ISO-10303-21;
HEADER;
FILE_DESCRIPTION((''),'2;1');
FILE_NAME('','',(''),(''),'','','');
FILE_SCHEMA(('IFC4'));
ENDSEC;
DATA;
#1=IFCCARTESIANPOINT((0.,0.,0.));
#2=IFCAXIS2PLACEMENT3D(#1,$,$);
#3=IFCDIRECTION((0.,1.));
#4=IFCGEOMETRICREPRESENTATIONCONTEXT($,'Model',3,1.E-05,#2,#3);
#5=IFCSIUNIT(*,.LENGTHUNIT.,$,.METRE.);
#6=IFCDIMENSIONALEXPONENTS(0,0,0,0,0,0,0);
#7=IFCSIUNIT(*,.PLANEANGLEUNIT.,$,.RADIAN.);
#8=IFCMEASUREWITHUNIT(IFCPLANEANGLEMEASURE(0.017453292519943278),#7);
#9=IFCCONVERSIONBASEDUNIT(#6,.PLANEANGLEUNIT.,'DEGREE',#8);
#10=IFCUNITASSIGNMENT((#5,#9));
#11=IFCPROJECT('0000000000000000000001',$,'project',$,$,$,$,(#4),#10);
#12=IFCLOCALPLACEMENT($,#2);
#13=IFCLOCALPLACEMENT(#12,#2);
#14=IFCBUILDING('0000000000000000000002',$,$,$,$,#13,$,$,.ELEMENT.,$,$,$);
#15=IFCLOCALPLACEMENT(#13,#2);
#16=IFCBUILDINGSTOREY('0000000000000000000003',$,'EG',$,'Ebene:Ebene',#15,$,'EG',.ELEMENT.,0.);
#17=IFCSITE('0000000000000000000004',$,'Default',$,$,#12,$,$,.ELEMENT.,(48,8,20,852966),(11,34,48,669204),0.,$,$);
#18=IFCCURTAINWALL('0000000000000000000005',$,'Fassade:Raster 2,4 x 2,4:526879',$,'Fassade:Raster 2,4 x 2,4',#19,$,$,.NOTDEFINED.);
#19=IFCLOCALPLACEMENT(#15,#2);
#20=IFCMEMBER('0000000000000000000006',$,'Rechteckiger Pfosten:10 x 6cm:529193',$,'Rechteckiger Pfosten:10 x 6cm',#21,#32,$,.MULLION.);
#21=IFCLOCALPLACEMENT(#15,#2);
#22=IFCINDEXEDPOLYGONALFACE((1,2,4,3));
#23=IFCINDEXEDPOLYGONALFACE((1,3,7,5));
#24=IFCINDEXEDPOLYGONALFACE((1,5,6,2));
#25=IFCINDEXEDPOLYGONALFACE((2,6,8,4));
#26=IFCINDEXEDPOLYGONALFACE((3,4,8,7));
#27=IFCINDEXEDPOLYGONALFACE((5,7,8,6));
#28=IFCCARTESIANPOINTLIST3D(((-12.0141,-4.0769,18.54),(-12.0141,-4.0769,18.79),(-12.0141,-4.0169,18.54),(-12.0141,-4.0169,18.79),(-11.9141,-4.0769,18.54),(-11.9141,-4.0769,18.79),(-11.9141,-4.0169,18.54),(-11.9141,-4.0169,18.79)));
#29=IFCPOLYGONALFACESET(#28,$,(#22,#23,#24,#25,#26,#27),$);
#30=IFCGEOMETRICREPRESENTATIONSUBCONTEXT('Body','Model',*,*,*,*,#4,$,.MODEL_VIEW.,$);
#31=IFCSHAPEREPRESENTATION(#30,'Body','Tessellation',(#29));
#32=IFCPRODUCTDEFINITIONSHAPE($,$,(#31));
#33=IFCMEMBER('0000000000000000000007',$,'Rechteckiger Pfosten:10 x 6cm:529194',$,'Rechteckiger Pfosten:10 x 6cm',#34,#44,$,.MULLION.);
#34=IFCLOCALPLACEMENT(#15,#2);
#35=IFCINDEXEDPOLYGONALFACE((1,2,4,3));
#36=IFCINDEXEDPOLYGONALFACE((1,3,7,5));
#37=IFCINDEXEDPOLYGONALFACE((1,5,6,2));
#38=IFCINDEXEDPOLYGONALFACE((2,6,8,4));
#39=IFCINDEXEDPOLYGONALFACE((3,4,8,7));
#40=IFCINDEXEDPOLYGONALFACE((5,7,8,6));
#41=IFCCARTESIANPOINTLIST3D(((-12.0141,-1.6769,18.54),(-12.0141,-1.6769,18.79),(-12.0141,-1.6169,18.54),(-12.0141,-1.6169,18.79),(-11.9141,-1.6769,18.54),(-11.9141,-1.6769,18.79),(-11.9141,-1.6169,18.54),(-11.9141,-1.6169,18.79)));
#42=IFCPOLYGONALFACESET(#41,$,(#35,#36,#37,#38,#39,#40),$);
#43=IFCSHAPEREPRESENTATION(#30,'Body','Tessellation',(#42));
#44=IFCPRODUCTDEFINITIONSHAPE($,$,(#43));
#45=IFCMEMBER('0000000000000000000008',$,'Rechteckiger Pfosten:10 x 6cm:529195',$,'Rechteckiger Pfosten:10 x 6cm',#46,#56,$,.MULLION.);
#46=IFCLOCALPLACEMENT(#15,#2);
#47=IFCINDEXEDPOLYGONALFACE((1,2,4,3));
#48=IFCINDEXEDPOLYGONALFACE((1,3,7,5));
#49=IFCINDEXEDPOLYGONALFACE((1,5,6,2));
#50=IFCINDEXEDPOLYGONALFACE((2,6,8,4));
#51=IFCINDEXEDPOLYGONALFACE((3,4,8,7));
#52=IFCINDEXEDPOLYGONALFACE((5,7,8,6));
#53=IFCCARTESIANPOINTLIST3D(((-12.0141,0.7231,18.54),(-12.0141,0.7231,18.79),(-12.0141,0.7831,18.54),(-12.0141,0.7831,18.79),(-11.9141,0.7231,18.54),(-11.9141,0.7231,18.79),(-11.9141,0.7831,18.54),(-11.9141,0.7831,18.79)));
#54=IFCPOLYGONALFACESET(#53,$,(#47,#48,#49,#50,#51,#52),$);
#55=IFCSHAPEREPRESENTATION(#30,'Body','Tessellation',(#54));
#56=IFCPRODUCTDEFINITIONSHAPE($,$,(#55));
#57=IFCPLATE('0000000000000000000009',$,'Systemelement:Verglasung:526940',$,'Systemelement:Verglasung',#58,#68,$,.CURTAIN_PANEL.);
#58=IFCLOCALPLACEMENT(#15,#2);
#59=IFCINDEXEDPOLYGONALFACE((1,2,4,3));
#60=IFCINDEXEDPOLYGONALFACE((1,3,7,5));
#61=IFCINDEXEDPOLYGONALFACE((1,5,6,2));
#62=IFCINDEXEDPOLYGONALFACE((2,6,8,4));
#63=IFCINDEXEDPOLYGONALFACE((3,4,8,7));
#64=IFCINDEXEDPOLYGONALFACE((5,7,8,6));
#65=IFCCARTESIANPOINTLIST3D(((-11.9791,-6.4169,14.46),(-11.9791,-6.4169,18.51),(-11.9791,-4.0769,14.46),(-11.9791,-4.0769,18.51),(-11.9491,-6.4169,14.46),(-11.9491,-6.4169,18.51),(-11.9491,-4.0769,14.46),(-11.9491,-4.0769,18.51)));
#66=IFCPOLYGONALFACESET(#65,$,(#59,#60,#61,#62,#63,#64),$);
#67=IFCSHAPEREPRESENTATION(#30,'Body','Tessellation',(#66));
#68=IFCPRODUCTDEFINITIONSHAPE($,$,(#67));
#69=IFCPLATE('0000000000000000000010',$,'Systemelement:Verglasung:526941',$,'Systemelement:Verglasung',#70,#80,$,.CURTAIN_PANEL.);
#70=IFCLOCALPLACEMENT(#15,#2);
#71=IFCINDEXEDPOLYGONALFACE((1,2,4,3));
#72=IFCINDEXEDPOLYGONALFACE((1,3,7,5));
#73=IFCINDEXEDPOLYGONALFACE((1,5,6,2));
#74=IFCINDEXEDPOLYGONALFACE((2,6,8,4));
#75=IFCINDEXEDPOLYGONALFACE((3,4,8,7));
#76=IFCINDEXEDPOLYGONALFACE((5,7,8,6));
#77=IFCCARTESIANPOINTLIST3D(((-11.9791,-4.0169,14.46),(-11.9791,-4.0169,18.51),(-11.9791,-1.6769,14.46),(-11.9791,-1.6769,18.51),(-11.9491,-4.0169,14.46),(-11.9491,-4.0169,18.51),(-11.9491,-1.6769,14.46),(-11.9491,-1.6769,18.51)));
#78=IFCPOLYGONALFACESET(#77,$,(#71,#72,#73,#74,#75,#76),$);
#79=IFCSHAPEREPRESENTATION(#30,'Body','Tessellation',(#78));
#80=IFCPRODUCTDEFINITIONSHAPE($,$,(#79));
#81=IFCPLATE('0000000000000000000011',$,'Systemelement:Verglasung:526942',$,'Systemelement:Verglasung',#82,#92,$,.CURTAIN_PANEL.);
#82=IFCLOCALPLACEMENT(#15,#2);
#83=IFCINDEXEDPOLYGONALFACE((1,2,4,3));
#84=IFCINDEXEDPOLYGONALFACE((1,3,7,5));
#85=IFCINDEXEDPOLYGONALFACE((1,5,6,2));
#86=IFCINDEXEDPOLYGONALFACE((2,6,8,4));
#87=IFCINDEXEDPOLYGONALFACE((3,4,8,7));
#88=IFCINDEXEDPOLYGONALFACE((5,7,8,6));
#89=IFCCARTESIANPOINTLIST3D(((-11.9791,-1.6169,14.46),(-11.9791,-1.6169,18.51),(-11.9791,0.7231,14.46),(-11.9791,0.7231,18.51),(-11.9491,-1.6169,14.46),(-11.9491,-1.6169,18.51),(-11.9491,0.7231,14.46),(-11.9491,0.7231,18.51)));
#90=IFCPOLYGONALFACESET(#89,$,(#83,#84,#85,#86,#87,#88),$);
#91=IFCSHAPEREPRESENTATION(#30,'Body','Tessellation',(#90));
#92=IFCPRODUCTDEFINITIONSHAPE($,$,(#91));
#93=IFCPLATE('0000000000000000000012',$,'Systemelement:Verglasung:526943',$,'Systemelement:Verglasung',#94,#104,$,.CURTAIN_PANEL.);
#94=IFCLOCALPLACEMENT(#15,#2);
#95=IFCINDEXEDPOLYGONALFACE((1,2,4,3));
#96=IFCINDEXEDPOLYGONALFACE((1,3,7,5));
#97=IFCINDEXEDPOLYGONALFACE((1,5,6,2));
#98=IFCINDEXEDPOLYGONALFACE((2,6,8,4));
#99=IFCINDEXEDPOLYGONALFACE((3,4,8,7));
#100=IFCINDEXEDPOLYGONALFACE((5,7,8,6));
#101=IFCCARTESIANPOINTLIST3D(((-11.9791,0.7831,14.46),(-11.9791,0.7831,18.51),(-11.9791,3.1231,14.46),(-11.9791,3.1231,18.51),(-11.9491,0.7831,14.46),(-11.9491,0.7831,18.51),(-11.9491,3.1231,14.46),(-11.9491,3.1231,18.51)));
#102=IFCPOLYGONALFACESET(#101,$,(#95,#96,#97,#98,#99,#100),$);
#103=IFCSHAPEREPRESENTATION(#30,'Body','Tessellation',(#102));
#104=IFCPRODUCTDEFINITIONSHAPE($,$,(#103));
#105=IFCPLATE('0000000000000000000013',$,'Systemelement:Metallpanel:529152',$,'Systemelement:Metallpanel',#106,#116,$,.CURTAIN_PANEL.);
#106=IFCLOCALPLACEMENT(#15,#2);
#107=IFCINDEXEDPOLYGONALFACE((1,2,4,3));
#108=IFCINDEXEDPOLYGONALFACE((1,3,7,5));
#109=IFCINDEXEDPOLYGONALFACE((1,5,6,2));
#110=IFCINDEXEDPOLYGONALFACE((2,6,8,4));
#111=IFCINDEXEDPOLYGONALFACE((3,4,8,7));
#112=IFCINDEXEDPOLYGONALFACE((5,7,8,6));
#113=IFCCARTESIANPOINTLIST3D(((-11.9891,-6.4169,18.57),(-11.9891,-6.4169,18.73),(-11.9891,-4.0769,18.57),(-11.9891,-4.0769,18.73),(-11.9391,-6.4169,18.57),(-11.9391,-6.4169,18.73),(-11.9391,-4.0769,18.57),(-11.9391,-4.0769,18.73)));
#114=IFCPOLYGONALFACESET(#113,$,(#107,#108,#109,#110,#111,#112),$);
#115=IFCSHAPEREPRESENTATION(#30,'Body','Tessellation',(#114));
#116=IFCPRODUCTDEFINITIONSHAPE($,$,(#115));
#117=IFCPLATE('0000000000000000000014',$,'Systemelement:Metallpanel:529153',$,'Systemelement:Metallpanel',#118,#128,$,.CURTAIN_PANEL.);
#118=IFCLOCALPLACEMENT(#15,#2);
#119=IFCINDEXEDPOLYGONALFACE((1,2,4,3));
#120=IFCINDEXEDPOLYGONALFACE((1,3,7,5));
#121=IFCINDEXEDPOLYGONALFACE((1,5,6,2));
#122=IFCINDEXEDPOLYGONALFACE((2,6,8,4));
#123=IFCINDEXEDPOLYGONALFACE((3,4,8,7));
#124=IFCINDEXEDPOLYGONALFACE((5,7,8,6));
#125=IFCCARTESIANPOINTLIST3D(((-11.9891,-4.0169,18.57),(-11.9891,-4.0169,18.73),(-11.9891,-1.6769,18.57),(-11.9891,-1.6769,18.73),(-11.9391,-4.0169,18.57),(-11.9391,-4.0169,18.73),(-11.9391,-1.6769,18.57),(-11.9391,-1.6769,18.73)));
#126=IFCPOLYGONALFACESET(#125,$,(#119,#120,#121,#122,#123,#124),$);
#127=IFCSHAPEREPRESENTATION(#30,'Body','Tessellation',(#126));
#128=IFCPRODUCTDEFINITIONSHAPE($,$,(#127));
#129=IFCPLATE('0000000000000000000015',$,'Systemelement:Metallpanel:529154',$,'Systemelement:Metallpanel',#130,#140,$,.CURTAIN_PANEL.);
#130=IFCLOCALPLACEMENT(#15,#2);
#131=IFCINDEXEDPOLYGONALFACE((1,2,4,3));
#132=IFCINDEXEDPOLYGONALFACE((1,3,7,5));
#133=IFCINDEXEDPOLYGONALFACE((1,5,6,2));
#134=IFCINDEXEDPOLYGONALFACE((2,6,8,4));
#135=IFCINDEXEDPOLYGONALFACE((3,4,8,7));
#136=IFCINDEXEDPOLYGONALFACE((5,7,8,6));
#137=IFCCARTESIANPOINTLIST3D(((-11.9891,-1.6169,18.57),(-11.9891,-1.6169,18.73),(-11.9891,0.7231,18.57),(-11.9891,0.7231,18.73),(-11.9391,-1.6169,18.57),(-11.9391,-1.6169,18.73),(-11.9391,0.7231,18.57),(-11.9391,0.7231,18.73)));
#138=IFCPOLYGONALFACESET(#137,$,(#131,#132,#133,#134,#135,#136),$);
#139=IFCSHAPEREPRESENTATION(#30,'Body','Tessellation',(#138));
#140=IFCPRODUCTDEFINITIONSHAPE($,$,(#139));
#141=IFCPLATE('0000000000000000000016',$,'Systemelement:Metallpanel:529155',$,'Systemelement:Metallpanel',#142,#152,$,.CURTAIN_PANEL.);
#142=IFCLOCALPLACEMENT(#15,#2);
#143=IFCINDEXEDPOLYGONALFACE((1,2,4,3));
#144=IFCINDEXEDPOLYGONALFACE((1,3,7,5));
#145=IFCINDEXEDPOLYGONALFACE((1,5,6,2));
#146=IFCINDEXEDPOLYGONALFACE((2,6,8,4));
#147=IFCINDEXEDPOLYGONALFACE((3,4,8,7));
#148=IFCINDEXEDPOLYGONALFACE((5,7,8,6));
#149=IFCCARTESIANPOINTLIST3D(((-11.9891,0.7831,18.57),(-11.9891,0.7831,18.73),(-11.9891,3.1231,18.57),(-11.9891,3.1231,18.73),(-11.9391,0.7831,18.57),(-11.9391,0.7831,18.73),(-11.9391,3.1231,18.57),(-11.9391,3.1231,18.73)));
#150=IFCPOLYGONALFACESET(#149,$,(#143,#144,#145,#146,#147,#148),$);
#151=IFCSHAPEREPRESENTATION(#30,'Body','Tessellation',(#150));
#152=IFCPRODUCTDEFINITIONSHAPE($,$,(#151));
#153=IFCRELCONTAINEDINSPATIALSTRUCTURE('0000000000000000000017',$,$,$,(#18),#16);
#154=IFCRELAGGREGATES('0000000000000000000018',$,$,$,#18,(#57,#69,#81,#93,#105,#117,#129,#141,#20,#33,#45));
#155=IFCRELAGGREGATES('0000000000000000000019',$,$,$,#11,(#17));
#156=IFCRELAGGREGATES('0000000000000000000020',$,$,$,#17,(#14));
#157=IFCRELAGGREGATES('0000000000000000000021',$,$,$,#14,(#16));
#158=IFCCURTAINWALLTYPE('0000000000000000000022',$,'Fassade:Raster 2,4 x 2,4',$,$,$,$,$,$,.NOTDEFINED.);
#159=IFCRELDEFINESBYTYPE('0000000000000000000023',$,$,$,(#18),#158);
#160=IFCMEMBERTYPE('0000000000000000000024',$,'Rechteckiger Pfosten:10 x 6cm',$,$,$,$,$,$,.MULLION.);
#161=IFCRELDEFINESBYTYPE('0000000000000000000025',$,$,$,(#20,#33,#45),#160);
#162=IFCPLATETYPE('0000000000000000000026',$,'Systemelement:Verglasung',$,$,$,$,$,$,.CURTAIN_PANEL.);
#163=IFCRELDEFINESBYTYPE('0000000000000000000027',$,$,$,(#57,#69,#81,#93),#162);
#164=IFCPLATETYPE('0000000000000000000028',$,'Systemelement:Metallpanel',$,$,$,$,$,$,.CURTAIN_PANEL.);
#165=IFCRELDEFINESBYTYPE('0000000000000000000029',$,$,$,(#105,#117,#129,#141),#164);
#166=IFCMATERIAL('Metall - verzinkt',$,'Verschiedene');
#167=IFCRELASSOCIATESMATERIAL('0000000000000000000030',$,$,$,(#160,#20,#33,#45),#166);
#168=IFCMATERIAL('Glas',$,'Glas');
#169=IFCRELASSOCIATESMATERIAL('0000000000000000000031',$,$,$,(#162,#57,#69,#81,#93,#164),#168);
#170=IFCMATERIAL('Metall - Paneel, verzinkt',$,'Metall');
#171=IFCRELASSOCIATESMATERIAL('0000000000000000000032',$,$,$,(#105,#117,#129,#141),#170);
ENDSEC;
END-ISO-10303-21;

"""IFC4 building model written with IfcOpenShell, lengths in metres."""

from ifc_helpers import new_model, entity, si_unit, converted_unit, direction, frame, origin, place, context, subcontext, project, spatial, indexed_curve, outline, extrude, source, transform, mapped, material, type_object, type_shapes, element, aggregate, save


model = new_model("IFC4")

# Units and contexts
model_context = context("Model", 3, precision=1e-05, world=origin(), true_north=direction((0.0, 1.0)))
body_context = subcontext(model_context, "Body", "Model", "MODEL_VIEW")
ifc_project = project(units=[si_unit("LENGTHUNIT", "METRE"), converted_unit("PLANEANGLEUNIT", "DEGREE", entity("IfcPlaneAngleMeasure", 0.017453292519943278), si_unit("PLANEANGLEUNIT", "RADIAN"), dimensions=[0, 0, 0, 0, 0, 0, 0])], contexts=[model_context])

# Site, building, storey
site_placement = place(None, origin())
site = spatial("IfcSite", under=ifc_project, at=site_placement, Name="Default", CompositionType="ELEMENT", RefLatitude=(48, 8, 20, 852966), RefLongitude=(11, 34, 48, 669204), RefElevation=0.0)
building_placement = place(site_placement, origin())
building = spatial("IfcBuilding", under=site, at=building_placement, CompositionType="ELEMENT")
storey_placement = place(building_placement, origin())
storey = spatial("IfcBuildingStorey", under=building, at=storey_placement, Name="EG", ObjectType="Ebene:Ebene", LongName="EG", CompositionType="ELEMENT", Elevation=0.0)

# Curtain wall, members, plates
curtain_wall_type = type_object("IfcCurtainWallType", Name="Fassade:Raster 2,4 x 2,4", PredefinedType="NOTDEFINED")
curtain_wall_placement = place(storey_placement, origin())
curtain_wall = element("IfcCurtainWall", 1, at=curtain_wall_placement, inside=storey, type_object=curtain_wall_type, Name="Fassade:Raster 2,4 x 2,4:526879", ObjectType="Fassade:Raster 2,4 x 2,4", PredefinedType="NOTDEFINED")
ifc_material_1 = material(Name="Metall - verzinkt", Category="Verschiedene")
member_type_1 = type_object("IfcMemberType", Name="Rechteckiger Pfosten:10 x 6cm", PredefinedType="MULLION", material=ifc_material_1)
shared_shape_1 = source(origin(), body_context, "Body", "SweptSolid", [
    extrude(outline(indexed_curve([(-0.03, -0.05), (0.03, -0.05), (0.03, 0.05), (-0.03, 0.05), (-0.03, -0.05)], self_intersect=False)), frame((0.0, 0.0, -0.25), z_axis=(0.0, 0.0, 1.0), x_axis=(-1.0, 0.0, 0.0)), (0.0, 0.0, 1.0), 0.25),
])
type_shapes(member_type_1, [shared_shape_1])
member_1_placement = place(curtain_wall_placement, frame((-11.9641, -4.0469, 18.54), z_axis=(0.0, 0.0, -1.0), x_axis=(0.0, 1.0, 0.0)))
member_1 = element("IfcMember", 2, at=member_1_placement, type_object=member_type_1, material=ifc_material_1, Name="Rechteckiger Pfosten:10 x 6cm:529193", ObjectType="Rechteckiger Pfosten:10 x 6cm", PredefinedType="MULLION", context=body_context, shape_type="MappedRepresentation", body=[
    mapped(shared_shape_1, transform((0.0, 0.0, 0.0), scale=1.0)),
])
member_2_placement = place(curtain_wall_placement, frame((-11.9641, -1.6469, 18.54), z_axis=(0.0, 0.0, -1.0), x_axis=(0.0, 1.0, 0.0)))
member_2 = element("IfcMember", 3, at=member_2_placement, type_object=member_type_1, material=ifc_material_1, Name="Rechteckiger Pfosten:10 x 6cm:529194", ObjectType="Rechteckiger Pfosten:10 x 6cm", PredefinedType="MULLION", context=body_context, shape_type="MappedRepresentation", body=[
    mapped(shared_shape_1, transform((0.0, 0.0, 0.0), scale=1.0)),
])
member_3_placement = place(curtain_wall_placement, frame((-11.9641, 0.7531, 18.54), z_axis=(0.0, 0.0, -1.0), x_axis=(0.0, 1.0, 0.0)))
member_3 = element("IfcMember", 4, at=member_3_placement, type_object=member_type_1, material=ifc_material_1, Name="Rechteckiger Pfosten:10 x 6cm:529195", ObjectType="Rechteckiger Pfosten:10 x 6cm", PredefinedType="MULLION", context=body_context, shape_type="MappedRepresentation", body=[
    mapped(shared_shape_1, transform((0.0, 0.0, 0.0), scale=1.0)),
])
ifc_material_2 = material(Name="Glas", Category="Glas")
plate_type_1 = type_object("IfcPlateType", Name="Systemelement:Verglasung", PredefinedType="CURTAIN_PANEL", material=ifc_material_2)
shared_shape_2 = source(origin(), body_context, "Body", "SweptSolid", [
    extrude(outline(indexed_curve([(-0.015, -1.17), (0.015, -1.17), (0.015, 1.17), (-0.015, 1.17), (-0.015, -1.17)], self_intersect=False)), frame((0.0, 0.0, 0.0), z_axis=(0.0, 0.0, 1.0), x_axis=(0.0, 1.0, 0.0)), (0.0, 0.0, 1.0), 4.05),
])
type_shapes(plate_type_1, [shared_shape_2])
plate_1_placement = place(curtain_wall_placement, frame((-11.9641, -5.2469, 14.46), z_axis=(0.0, 0.0, 1.0), x_axis=(0.0, 1.0, 0.0)))
plate_1 = element("IfcPlate", 5, at=plate_1_placement, type_object=plate_type_1, material=ifc_material_2, Name="Systemelement:Verglasung:526940", ObjectType="Systemelement:Verglasung", PredefinedType="CURTAIN_PANEL", context=body_context, shape_type="MappedRepresentation", body=[
    mapped(shared_shape_2, transform((0.0, 0.0, 0.0), scale=1.0)),
])
plate_2_placement = place(curtain_wall_placement, frame((-11.9641, -2.8469, 14.46), z_axis=(0.0, 0.0, 1.0), x_axis=(0.0, 1.0, 0.0)))
plate_2 = element("IfcPlate", 6, at=plate_2_placement, type_object=plate_type_1, material=ifc_material_2, Name="Systemelement:Verglasung:526941", ObjectType="Systemelement:Verglasung", PredefinedType="CURTAIN_PANEL", context=body_context, shape_type="MappedRepresentation", body=[
    mapped(shared_shape_2, transform((0.0, 0.0, 0.0), scale=1.0)),
])
plate_3_placement = place(curtain_wall_placement, frame((-11.9641, -0.4469, 14.46), z_axis=(0.0, 0.0, 1.0), x_axis=(0.0, 1.0, 0.0)))
plate_3 = element("IfcPlate", 7, at=plate_3_placement, type_object=plate_type_1, material=ifc_material_2, Name="Systemelement:Verglasung:526942", ObjectType="Systemelement:Verglasung", PredefinedType="CURTAIN_PANEL", context=body_context, shape_type="MappedRepresentation", body=[
    mapped(shared_shape_2, transform((0.0, 0.0, 0.0), scale=1.0)),
])
plate_4_placement = place(curtain_wall_placement, frame((-11.9641, 1.9531, 14.46), z_axis=(0.0, 0.0, 1.0), x_axis=(0.0, 1.0, 0.0)))
plate_4 = element("IfcPlate", 8, at=plate_4_placement, type_object=plate_type_1, material=ifc_material_2, Name="Systemelement:Verglasung:526943", ObjectType="Systemelement:Verglasung", PredefinedType="CURTAIN_PANEL", context=body_context, shape_type="MappedRepresentation", body=[
    mapped(shared_shape_2, transform((0.0, 0.0, 0.0), scale=1.0)),
])
ifc_material_3 = material(Name="Metall - Paneel, verzinkt", Category="Metall")
plate_type_2 = type_object("IfcPlateType", Name="Systemelement:Metallpanel", PredefinedType="CURTAIN_PANEL", material=ifc_material_2)
shared_shape_3 = source(origin(), body_context, "Body", "SweptSolid", [
    extrude(outline(indexed_curve([(-0.025, -1.17), (0.025, -1.17), (0.025, 1.17), (-0.025, 1.17), (-0.025, -1.17)], self_intersect=False)), frame((0.0, 0.0, 0.0), z_axis=(0.0, 0.0, 1.0), x_axis=(0.0, 1.0, 0.0)), (0.0, 0.0, 1.0), 0.16),
])
type_shapes(plate_type_2, [shared_shape_3])
plate_5_placement = place(curtain_wall_placement, frame((-11.9641, -5.2469, 18.57), z_axis=(0.0, 0.0, 1.0), x_axis=(0.0, 1.0, 0.0)))
plate_5 = element("IfcPlate", 9, at=plate_5_placement, type_object=plate_type_2, material=ifc_material_3, Name="Systemelement:Metallpanel:529152", ObjectType="Systemelement:Metallpanel", PredefinedType="CURTAIN_PANEL", context=body_context, shape_type="MappedRepresentation", body=[
    mapped(shared_shape_3, transform((0.0, 0.0, 0.0), scale=1.0)),
])
plate_6_placement = place(curtain_wall_placement, frame((-11.9641, -2.8469, 18.57), z_axis=(0.0, 0.0, 1.0), x_axis=(0.0, 1.0, 0.0)))
plate_6 = element("IfcPlate", 10, at=plate_6_placement, type_object=plate_type_2, material=ifc_material_3, Name="Systemelement:Metallpanel:529153", ObjectType="Systemelement:Metallpanel", PredefinedType="CURTAIN_PANEL", context=body_context, shape_type="MappedRepresentation", body=[
    mapped(shared_shape_3, transform((0.0, 0.0, 0.0), scale=1.0)),
])
plate_7_placement = place(curtain_wall_placement, frame((-11.9641, -0.4469, 18.57), z_axis=(0.0, 0.0, 1.0), x_axis=(0.0, 1.0, 0.0)))
plate_7 = element("IfcPlate", 11, at=plate_7_placement, type_object=plate_type_2, material=ifc_material_3, Name="Systemelement:Metallpanel:529154", ObjectType="Systemelement:Metallpanel", PredefinedType="CURTAIN_PANEL", context=body_context, shape_type="MappedRepresentation", body=[
    mapped(shared_shape_3, transform((0.0, 0.0, 0.0), scale=1.0)),
])
plate_8_placement = place(curtain_wall_placement, frame((-11.9641, 1.9531, 18.57), z_axis=(0.0, 0.0, 1.0), x_axis=(0.0, 1.0, 0.0)))
plate_8 = element("IfcPlate", 12, at=plate_8_placement, type_object=plate_type_2, material=ifc_material_3, Name="Systemelement:Metallpanel:529155", ObjectType="Systemelement:Metallpanel", PredefinedType="CURTAIN_PANEL", context=body_context, shape_type="MappedRepresentation", body=[
    mapped(shared_shape_3, transform((0.0, 0.0, 0.0), scale=1.0)),
])
aggregate(curtain_wall, [plate_1, plate_2, plate_3, plate_4, plate_5, plate_6, plate_7, plate_8, member_1, member_2, member_3])

save(model, "model.ifc")
